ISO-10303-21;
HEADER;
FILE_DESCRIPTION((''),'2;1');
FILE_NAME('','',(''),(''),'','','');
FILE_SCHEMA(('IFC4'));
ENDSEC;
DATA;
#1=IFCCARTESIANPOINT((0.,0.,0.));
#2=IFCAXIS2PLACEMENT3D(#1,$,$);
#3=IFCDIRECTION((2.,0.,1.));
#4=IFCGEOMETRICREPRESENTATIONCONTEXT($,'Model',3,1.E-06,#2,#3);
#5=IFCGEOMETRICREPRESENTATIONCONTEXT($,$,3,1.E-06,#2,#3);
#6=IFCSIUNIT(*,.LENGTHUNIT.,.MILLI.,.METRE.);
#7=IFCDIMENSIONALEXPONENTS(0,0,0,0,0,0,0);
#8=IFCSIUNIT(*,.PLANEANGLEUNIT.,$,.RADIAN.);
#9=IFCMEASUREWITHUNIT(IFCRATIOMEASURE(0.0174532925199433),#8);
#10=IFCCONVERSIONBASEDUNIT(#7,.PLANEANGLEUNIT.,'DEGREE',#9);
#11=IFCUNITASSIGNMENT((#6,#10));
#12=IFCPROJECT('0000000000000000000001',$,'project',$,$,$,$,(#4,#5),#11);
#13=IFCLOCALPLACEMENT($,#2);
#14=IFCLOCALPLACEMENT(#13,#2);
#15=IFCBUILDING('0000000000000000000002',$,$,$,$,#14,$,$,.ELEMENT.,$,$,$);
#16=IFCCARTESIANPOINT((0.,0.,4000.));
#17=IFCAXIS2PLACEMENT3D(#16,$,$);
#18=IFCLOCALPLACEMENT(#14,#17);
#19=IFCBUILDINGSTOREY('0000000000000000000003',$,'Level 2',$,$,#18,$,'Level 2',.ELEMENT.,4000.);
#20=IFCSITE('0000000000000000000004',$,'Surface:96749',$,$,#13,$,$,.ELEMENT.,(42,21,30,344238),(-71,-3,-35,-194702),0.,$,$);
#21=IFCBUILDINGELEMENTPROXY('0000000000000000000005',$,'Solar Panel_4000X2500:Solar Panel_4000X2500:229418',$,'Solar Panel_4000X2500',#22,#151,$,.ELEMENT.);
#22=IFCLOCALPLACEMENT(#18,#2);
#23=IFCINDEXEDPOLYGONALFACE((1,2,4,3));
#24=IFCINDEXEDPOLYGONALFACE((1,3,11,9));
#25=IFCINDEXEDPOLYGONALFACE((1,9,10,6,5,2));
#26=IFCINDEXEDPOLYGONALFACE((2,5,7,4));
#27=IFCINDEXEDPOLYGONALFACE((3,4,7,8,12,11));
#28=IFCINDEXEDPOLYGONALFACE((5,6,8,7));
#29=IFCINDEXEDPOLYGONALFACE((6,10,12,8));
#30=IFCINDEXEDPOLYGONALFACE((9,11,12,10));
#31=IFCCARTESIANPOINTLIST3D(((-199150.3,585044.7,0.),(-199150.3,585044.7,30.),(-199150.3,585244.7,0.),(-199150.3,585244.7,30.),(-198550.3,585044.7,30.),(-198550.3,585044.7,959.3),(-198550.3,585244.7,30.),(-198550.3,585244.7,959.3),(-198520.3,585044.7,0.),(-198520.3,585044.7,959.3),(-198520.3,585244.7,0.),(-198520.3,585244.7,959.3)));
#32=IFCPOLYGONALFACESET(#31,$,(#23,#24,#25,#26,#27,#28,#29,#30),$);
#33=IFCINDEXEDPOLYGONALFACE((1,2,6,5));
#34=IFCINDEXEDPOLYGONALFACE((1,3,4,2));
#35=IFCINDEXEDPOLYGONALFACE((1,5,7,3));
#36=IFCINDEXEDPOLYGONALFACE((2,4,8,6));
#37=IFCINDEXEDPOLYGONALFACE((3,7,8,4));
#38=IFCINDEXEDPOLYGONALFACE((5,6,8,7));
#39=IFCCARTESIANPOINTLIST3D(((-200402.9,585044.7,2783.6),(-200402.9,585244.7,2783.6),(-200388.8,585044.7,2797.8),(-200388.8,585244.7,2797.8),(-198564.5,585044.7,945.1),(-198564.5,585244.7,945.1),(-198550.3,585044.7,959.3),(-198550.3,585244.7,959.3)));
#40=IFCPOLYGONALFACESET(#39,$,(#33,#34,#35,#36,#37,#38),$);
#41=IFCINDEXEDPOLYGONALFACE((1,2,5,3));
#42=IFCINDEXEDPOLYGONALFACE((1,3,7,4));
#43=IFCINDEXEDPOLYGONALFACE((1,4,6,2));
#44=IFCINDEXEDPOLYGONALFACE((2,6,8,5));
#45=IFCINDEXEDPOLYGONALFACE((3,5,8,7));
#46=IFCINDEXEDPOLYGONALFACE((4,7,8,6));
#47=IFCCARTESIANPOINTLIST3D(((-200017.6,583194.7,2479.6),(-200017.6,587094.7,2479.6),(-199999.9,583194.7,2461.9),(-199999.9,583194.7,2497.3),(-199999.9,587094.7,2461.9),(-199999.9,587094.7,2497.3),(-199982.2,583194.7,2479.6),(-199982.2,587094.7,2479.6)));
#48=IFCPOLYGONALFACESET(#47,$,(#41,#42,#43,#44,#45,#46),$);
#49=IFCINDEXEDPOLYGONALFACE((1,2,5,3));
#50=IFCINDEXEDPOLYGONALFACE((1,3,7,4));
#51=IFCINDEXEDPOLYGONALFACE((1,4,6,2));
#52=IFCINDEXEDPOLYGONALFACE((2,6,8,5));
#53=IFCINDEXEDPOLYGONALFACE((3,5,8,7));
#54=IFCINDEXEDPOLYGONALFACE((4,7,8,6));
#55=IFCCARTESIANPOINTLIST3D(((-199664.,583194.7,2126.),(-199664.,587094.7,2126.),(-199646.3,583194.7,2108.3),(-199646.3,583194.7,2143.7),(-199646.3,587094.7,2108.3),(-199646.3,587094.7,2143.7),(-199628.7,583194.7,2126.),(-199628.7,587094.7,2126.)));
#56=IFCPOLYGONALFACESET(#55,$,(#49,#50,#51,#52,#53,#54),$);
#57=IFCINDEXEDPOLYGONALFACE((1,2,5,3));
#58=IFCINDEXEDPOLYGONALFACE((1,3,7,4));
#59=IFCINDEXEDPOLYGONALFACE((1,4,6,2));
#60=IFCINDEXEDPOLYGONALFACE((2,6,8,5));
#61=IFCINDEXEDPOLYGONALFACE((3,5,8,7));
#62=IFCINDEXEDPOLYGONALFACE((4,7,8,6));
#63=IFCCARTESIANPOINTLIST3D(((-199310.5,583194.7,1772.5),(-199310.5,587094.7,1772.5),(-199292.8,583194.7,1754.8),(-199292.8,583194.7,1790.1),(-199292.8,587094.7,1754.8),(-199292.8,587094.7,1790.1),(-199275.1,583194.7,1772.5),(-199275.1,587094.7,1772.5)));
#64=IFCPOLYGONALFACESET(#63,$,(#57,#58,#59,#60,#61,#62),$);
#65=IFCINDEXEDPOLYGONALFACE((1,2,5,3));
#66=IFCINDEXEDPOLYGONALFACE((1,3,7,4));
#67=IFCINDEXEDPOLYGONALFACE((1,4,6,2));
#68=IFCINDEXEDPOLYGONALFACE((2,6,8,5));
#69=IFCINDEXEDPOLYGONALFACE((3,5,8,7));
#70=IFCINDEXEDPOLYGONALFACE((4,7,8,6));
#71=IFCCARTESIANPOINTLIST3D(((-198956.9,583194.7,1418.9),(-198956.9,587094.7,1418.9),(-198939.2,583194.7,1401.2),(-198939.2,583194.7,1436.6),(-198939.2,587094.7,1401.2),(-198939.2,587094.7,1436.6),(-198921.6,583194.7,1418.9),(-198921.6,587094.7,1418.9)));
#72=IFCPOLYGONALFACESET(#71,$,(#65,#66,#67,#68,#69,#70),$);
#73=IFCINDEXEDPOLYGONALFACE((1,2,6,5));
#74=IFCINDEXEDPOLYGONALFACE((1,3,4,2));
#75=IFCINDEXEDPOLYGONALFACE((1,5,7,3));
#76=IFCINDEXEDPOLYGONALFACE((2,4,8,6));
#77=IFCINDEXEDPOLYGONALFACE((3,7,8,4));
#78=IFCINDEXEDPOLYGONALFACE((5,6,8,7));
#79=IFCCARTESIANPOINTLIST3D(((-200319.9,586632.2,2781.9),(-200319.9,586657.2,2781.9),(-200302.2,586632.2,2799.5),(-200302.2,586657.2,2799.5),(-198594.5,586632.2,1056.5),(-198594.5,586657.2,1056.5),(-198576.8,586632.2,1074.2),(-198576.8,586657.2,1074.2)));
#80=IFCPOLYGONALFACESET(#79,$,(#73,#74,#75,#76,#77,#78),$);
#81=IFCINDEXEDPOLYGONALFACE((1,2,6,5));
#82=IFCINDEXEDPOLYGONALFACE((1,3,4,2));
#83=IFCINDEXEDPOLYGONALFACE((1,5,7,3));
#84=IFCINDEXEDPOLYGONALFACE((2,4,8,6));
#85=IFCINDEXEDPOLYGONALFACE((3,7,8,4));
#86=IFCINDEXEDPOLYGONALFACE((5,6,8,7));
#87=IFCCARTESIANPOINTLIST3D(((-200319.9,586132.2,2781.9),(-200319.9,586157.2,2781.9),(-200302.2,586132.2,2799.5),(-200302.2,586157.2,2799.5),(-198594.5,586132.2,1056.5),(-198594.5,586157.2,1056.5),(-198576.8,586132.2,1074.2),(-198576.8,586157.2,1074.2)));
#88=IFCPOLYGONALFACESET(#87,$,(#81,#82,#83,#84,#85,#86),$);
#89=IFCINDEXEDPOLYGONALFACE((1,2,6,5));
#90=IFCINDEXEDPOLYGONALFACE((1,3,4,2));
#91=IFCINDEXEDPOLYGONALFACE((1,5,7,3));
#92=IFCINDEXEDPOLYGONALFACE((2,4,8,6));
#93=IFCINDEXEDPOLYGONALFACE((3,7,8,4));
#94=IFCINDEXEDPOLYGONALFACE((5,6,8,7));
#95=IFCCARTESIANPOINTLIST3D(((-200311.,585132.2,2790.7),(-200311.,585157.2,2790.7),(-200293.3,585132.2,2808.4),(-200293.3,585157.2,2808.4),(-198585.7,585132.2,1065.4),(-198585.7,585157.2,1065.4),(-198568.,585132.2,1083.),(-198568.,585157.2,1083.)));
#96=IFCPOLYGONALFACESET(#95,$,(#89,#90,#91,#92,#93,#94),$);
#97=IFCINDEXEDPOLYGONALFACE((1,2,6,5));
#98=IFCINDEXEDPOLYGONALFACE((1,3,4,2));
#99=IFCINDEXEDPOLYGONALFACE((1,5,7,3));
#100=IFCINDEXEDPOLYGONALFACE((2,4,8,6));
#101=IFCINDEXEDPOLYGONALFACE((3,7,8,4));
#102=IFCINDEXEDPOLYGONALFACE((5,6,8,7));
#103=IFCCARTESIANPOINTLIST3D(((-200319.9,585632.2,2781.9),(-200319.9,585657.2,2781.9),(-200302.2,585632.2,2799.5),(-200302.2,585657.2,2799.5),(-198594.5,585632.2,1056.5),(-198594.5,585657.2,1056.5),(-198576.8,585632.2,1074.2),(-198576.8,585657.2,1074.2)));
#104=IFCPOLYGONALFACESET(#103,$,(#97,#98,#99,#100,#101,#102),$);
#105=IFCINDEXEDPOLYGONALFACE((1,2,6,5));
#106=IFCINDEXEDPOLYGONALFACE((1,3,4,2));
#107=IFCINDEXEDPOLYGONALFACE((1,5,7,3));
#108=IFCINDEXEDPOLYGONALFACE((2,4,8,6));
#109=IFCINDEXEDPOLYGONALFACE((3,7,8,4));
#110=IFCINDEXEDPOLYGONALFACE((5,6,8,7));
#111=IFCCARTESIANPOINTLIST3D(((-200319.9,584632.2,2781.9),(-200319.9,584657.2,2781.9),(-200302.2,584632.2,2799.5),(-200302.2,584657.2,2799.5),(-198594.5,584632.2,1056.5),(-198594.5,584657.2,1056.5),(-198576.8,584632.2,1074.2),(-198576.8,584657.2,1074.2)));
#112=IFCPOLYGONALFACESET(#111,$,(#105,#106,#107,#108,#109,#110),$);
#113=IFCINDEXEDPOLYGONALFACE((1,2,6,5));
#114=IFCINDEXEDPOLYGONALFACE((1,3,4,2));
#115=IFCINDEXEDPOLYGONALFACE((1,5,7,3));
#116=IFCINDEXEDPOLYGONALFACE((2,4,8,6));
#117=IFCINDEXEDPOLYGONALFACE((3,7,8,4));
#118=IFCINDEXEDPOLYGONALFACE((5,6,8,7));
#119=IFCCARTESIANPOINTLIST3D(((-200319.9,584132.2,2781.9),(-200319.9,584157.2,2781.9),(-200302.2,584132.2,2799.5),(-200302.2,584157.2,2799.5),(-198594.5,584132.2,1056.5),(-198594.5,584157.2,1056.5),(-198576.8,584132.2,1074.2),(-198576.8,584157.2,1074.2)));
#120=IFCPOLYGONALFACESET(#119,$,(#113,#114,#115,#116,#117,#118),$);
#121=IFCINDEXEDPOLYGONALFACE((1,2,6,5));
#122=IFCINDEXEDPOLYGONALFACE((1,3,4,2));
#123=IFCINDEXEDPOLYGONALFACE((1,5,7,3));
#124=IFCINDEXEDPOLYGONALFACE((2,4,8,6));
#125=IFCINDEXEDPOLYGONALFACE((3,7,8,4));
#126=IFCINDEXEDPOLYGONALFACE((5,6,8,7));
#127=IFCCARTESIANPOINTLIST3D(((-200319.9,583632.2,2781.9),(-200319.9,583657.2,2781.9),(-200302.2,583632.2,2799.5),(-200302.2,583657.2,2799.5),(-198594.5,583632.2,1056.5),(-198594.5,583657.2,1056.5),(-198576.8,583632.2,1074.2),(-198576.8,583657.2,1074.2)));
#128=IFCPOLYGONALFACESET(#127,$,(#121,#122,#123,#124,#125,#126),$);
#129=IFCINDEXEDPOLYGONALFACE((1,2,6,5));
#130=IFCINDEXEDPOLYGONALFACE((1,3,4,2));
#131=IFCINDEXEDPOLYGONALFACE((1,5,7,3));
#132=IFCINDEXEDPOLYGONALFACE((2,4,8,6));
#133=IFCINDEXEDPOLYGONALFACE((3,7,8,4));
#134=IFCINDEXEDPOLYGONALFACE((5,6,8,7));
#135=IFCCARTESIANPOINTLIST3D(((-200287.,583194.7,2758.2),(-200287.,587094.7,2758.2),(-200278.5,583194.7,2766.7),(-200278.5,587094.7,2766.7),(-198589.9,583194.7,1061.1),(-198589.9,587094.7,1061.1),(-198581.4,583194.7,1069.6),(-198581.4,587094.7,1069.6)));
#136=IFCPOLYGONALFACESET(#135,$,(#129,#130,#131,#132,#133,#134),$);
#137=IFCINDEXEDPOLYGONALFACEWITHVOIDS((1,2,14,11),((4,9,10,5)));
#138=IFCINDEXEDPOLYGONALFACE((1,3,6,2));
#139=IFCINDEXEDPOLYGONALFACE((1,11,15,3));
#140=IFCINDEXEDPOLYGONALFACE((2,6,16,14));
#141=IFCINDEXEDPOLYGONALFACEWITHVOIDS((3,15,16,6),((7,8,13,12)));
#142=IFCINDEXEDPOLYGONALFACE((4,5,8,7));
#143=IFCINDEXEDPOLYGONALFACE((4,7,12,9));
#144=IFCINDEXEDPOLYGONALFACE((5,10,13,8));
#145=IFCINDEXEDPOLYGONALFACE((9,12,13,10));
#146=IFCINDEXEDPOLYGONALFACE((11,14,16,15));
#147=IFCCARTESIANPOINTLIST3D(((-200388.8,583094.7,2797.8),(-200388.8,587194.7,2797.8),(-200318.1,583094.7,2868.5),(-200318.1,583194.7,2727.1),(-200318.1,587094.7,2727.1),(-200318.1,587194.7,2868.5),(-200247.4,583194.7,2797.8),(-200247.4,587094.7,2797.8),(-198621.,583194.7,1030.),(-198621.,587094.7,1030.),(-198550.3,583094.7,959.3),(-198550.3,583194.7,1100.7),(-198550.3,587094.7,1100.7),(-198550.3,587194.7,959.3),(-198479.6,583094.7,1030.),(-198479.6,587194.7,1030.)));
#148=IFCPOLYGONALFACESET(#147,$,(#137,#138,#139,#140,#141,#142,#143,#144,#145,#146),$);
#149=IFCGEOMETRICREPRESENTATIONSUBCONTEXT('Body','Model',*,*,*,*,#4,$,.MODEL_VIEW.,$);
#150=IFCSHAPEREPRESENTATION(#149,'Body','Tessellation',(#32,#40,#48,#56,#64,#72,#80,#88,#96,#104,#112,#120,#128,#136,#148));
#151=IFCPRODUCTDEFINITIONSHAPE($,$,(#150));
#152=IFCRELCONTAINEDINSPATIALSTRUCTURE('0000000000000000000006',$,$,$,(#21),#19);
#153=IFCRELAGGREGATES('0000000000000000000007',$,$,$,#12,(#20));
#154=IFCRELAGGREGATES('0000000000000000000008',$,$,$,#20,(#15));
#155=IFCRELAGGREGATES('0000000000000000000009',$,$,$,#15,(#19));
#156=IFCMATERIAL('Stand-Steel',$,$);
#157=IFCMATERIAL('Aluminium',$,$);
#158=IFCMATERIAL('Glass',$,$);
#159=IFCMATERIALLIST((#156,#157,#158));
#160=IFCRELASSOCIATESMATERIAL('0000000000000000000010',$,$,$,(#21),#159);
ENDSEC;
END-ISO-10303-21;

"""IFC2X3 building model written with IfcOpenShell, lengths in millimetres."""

from ifc_helpers import new_model, entity, si_unit, converted_unit, direction, frame, frame_2d, origin, origin_2d_with_axis, place, context, subcontext, project, spatial, polyline, rectangle, outline, extrude, source, transform, mapped, material, material_list, element, save


model = new_model("IFC2X3")

# Units and contexts
model_context = context("Model", 3, precision=1e-06, world=origin(), true_north=direction((2.0, 0.0, 1.0)))
context_of_model = context(None, 3, precision=1e-06, world=origin(), true_north=direction((2.0, 0.0, 1.0)))
body_context = subcontext(model_context, "Body", "Model", "MODEL_VIEW")
ifc_project = project(units=[si_unit("LENGTHUNIT", "METRE", prefix="MILLI"), converted_unit("PLANEANGLEUNIT", "DEGREE", entity("IfcRatioMeasure", 0.0174532925199433), si_unit("PLANEANGLEUNIT", "RADIAN"), dimensions=[0, 0, 0, 0, 0, 0, 0])], contexts=[model_context, context_of_model])

# Site, building, storey
site_placement = place(None, origin())
site = spatial("IfcSite", under=ifc_project, at=site_placement, Name="Surface:96749", CompositionType="ELEMENT", RefLatitude=(42, 21, 30, 344238), RefLongitude=(-71, -3, -35, -194702), RefElevation=0.0)
building_placement = place(site_placement, origin())
building = spatial("IfcBuilding", under=site, at=building_placement, CompositionType="ELEMENT")
storey_placement = place(building_placement, frame((0.0, 0.0, 4000.0)))
storey = spatial("IfcBuildingStorey", under=building, at=storey_placement, Name="Level 2", LongName="Level 2", CompositionType="ELEMENT", Elevation=4000.0)

# Building element proxy
ifc_material_1 = material(Name="Stand-Steel")
ifc_material_2 = material(Name="Aluminium")
ifc_material_3 = material(Name="Glass")
shared_shape = source(origin(), body_context, "Body", "SweptSolid", [
    extrude(outline(polyline([(-629.5, -220.0), (329.8, -220.0), (329.8, 410.0), (299.8, 410.0), (299.8, -190.0), (-629.5, -190.0), (-629.5, -220.0)])), frame((-190.0, -100.0, 299.8), z_axis=(0.0, 1.0, 0.0), x_axis=(0.0, 0.0, -1.0)), (0.0, 0.0, 1.0), 200.0),
    extrude(rectangle(XDim=20.0, YDim=200.0, at=frame_2d((0.0, 0.0), x_axis=(0.0, 1.0))), frame((-7.1, 0.0, 922.2), z_axis=(-0.707107, 0.0, 0.707107), x_axis=(0.0, 1.0, 0.0)), (0.0, 0.0, 1.0), 2600.0),
    extrude(rectangle(XDim=25.0, YDim=25.0, at=frame_2d((0.0, 0.0), x_axis=(1.0, 0.0))), frame((-1449.6, -1950.0, 2449.6), z_axis=(0.0, 1.0, 0.0), x_axis=(-0.707107, 0.0, -0.707107)), (0.0, 0.0, 1.0), 3900.0),
    extrude(rectangle(XDim=25.0, YDim=25.0, at=origin_2d_with_axis()), frame((-1096.0, -1950.0, 2096.0), z_axis=(0.0, 1.0, 0.0), x_axis=(-0.707107, 0.0, -0.707107)), (0.0, 0.0, 1.0), 3900.0),
    extrude(rectangle(XDim=25.0, YDim=25.0, at=origin_2d_with_axis()), frame((-742.5, -1950.0, 1742.5), z_axis=(0.0, 1.0, 0.0), x_axis=(-0.707107, 0.0, -0.707107)), (0.0, 0.0, 1.0), 3900.0),
    extrude(rectangle(XDim=25.0, YDim=25.0, at=frame_2d((0.0, 0.0), x_axis=(1.0, 0.0))), frame((-388.9, -1950.0, 1388.9), z_axis=(0.0, 1.0, 0.0), x_axis=(-0.707107, 0.0, -0.707107)), (0.0, 0.0, 1.0), 3900.0),
    extrude(rectangle(XDim=25.0, YDim=25.0, at=frame_2d((0.0, 0.0), x_axis=(0.0, 1.0))), frame((-35.4, 1500.0, 1035.4), z_axis=(-0.707107, 0.0, 0.707107), x_axis=(0.0, 1.0, 0.0)), (0.0, 0.0, 1.0), 2440.0),
    extrude(rectangle(XDim=25.0, YDim=25.0, at=frame_2d((0.0, 0.0), x_axis=(0.0, 1.0))), frame((-35.4, 1000.0, 1035.4), z_axis=(-0.707107, 0.0, 0.707107), x_axis=(0.0, 1.0, 0.0)), (0.0, 0.0, 1.0), 2440.0),
    extrude(rectangle(XDim=25.0, YDim=25.0, at=frame_2d((0.0, 0.0), x_axis=(0.0, 1.0))), frame((-26.5, 0.0, 1044.2), z_axis=(-0.707107, 0.0, 0.707107), x_axis=(0.0, -1.0, 0.0)), (0.0, 0.0, 1.0), 2440.0),
    extrude(rectangle(XDim=25.0, YDim=25.0, at=frame_2d((0.0, 0.0), x_axis=(0.0, 1.0))), frame((-35.4, 500.0, 1035.4), z_axis=(-0.707107, 0.0, 0.707107), x_axis=(0.0, 1.0, 0.0)), (0.0, 0.0, 1.0), 2440.0),
    extrude(rectangle(XDim=25.0, YDim=25.0, at=frame_2d((0.0, 0.0), x_axis=(0.0, 1.0))), frame((-35.4, -500.0, 1035.4), z_axis=(-0.707107, 0.0, 0.707107), x_axis=(0.0, 1.0, 0.0)), (0.0, 0.0, 1.0), 2440.0),
    extrude(rectangle(XDim=25.0, YDim=25.0, at=frame_2d((0.0, 0.0), x_axis=(0.0, 1.0))), frame((-35.4, -1000.0, 1035.4), z_axis=(-0.707107, 0.0, 0.707107), x_axis=(0.0, 1.0, 0.0)), (0.0, 0.0, 1.0), 2440.0),
    extrude(rectangle(XDim=25.0, YDim=25.0, at=frame_2d((0.0, 0.0), x_axis=(0.0, 1.0))), frame((-35.4, -1500.0, 1035.4), z_axis=(-0.707107, 0.0, 0.707107), x_axis=(0.0, 1.0, 0.0)), (0.0, 0.0, 1.0), 2440.0),
    extrude(rectangle(XDim=2400.0, YDim=12.0, at=frame_2d((0.0, 0.0), x_axis=(1.0, 0.0))), frame((-883.9, -1950.0, 1883.9), z_axis=(0.0, 1.0, 0.0), x_axis=(0.707107, 0.0, -0.707107)), (0.0, 0.0, 1.0), 3900.0),
    extrude(outline(polyline([(-2050.0, -1300.0), (2050.0, -1300.0), (2050.0, 1300.0), (-2050.0, 1300.0), (-2050.0, -1300.0)]), holes=[polyline([(1950.0, -1200.0), (-1950.0, -1200.0), (-1950.0, 1200.0), (1950.0, 1200.0), (1950.0, -1200.0)])]), frame((-919.2, 0.0, 1848.5), z_axis=(0.707107, 0.0, 0.707107), x_axis=(0.0, 1.0, 0.0)), (0.0, 0.0, 1.0), 100.0),
])
ifc_material_list_1 = material_list([ifc_material_1, ifc_material_2, ifc_material_3])
proxy_1_placement = place(storey_placement, frame((-198550.3, 585144.7, 30.0)))
element("IfcBuildingElementProxy", 1, at=proxy_1_placement, inside=storey, material=ifc_material_list_1, Name="Solar Panel_4000X2500:Solar Panel_4000X2500:229418", ObjectType="Solar Panel_4000X2500", CompositionType="ELEMENT", context=body_context, shape_type="MappedRepresentation", body=[
    mapped(shared_shape, transform((0.0, 0.0, 0.0), scale=1.0)),
])

save(model, "model.ifc")
